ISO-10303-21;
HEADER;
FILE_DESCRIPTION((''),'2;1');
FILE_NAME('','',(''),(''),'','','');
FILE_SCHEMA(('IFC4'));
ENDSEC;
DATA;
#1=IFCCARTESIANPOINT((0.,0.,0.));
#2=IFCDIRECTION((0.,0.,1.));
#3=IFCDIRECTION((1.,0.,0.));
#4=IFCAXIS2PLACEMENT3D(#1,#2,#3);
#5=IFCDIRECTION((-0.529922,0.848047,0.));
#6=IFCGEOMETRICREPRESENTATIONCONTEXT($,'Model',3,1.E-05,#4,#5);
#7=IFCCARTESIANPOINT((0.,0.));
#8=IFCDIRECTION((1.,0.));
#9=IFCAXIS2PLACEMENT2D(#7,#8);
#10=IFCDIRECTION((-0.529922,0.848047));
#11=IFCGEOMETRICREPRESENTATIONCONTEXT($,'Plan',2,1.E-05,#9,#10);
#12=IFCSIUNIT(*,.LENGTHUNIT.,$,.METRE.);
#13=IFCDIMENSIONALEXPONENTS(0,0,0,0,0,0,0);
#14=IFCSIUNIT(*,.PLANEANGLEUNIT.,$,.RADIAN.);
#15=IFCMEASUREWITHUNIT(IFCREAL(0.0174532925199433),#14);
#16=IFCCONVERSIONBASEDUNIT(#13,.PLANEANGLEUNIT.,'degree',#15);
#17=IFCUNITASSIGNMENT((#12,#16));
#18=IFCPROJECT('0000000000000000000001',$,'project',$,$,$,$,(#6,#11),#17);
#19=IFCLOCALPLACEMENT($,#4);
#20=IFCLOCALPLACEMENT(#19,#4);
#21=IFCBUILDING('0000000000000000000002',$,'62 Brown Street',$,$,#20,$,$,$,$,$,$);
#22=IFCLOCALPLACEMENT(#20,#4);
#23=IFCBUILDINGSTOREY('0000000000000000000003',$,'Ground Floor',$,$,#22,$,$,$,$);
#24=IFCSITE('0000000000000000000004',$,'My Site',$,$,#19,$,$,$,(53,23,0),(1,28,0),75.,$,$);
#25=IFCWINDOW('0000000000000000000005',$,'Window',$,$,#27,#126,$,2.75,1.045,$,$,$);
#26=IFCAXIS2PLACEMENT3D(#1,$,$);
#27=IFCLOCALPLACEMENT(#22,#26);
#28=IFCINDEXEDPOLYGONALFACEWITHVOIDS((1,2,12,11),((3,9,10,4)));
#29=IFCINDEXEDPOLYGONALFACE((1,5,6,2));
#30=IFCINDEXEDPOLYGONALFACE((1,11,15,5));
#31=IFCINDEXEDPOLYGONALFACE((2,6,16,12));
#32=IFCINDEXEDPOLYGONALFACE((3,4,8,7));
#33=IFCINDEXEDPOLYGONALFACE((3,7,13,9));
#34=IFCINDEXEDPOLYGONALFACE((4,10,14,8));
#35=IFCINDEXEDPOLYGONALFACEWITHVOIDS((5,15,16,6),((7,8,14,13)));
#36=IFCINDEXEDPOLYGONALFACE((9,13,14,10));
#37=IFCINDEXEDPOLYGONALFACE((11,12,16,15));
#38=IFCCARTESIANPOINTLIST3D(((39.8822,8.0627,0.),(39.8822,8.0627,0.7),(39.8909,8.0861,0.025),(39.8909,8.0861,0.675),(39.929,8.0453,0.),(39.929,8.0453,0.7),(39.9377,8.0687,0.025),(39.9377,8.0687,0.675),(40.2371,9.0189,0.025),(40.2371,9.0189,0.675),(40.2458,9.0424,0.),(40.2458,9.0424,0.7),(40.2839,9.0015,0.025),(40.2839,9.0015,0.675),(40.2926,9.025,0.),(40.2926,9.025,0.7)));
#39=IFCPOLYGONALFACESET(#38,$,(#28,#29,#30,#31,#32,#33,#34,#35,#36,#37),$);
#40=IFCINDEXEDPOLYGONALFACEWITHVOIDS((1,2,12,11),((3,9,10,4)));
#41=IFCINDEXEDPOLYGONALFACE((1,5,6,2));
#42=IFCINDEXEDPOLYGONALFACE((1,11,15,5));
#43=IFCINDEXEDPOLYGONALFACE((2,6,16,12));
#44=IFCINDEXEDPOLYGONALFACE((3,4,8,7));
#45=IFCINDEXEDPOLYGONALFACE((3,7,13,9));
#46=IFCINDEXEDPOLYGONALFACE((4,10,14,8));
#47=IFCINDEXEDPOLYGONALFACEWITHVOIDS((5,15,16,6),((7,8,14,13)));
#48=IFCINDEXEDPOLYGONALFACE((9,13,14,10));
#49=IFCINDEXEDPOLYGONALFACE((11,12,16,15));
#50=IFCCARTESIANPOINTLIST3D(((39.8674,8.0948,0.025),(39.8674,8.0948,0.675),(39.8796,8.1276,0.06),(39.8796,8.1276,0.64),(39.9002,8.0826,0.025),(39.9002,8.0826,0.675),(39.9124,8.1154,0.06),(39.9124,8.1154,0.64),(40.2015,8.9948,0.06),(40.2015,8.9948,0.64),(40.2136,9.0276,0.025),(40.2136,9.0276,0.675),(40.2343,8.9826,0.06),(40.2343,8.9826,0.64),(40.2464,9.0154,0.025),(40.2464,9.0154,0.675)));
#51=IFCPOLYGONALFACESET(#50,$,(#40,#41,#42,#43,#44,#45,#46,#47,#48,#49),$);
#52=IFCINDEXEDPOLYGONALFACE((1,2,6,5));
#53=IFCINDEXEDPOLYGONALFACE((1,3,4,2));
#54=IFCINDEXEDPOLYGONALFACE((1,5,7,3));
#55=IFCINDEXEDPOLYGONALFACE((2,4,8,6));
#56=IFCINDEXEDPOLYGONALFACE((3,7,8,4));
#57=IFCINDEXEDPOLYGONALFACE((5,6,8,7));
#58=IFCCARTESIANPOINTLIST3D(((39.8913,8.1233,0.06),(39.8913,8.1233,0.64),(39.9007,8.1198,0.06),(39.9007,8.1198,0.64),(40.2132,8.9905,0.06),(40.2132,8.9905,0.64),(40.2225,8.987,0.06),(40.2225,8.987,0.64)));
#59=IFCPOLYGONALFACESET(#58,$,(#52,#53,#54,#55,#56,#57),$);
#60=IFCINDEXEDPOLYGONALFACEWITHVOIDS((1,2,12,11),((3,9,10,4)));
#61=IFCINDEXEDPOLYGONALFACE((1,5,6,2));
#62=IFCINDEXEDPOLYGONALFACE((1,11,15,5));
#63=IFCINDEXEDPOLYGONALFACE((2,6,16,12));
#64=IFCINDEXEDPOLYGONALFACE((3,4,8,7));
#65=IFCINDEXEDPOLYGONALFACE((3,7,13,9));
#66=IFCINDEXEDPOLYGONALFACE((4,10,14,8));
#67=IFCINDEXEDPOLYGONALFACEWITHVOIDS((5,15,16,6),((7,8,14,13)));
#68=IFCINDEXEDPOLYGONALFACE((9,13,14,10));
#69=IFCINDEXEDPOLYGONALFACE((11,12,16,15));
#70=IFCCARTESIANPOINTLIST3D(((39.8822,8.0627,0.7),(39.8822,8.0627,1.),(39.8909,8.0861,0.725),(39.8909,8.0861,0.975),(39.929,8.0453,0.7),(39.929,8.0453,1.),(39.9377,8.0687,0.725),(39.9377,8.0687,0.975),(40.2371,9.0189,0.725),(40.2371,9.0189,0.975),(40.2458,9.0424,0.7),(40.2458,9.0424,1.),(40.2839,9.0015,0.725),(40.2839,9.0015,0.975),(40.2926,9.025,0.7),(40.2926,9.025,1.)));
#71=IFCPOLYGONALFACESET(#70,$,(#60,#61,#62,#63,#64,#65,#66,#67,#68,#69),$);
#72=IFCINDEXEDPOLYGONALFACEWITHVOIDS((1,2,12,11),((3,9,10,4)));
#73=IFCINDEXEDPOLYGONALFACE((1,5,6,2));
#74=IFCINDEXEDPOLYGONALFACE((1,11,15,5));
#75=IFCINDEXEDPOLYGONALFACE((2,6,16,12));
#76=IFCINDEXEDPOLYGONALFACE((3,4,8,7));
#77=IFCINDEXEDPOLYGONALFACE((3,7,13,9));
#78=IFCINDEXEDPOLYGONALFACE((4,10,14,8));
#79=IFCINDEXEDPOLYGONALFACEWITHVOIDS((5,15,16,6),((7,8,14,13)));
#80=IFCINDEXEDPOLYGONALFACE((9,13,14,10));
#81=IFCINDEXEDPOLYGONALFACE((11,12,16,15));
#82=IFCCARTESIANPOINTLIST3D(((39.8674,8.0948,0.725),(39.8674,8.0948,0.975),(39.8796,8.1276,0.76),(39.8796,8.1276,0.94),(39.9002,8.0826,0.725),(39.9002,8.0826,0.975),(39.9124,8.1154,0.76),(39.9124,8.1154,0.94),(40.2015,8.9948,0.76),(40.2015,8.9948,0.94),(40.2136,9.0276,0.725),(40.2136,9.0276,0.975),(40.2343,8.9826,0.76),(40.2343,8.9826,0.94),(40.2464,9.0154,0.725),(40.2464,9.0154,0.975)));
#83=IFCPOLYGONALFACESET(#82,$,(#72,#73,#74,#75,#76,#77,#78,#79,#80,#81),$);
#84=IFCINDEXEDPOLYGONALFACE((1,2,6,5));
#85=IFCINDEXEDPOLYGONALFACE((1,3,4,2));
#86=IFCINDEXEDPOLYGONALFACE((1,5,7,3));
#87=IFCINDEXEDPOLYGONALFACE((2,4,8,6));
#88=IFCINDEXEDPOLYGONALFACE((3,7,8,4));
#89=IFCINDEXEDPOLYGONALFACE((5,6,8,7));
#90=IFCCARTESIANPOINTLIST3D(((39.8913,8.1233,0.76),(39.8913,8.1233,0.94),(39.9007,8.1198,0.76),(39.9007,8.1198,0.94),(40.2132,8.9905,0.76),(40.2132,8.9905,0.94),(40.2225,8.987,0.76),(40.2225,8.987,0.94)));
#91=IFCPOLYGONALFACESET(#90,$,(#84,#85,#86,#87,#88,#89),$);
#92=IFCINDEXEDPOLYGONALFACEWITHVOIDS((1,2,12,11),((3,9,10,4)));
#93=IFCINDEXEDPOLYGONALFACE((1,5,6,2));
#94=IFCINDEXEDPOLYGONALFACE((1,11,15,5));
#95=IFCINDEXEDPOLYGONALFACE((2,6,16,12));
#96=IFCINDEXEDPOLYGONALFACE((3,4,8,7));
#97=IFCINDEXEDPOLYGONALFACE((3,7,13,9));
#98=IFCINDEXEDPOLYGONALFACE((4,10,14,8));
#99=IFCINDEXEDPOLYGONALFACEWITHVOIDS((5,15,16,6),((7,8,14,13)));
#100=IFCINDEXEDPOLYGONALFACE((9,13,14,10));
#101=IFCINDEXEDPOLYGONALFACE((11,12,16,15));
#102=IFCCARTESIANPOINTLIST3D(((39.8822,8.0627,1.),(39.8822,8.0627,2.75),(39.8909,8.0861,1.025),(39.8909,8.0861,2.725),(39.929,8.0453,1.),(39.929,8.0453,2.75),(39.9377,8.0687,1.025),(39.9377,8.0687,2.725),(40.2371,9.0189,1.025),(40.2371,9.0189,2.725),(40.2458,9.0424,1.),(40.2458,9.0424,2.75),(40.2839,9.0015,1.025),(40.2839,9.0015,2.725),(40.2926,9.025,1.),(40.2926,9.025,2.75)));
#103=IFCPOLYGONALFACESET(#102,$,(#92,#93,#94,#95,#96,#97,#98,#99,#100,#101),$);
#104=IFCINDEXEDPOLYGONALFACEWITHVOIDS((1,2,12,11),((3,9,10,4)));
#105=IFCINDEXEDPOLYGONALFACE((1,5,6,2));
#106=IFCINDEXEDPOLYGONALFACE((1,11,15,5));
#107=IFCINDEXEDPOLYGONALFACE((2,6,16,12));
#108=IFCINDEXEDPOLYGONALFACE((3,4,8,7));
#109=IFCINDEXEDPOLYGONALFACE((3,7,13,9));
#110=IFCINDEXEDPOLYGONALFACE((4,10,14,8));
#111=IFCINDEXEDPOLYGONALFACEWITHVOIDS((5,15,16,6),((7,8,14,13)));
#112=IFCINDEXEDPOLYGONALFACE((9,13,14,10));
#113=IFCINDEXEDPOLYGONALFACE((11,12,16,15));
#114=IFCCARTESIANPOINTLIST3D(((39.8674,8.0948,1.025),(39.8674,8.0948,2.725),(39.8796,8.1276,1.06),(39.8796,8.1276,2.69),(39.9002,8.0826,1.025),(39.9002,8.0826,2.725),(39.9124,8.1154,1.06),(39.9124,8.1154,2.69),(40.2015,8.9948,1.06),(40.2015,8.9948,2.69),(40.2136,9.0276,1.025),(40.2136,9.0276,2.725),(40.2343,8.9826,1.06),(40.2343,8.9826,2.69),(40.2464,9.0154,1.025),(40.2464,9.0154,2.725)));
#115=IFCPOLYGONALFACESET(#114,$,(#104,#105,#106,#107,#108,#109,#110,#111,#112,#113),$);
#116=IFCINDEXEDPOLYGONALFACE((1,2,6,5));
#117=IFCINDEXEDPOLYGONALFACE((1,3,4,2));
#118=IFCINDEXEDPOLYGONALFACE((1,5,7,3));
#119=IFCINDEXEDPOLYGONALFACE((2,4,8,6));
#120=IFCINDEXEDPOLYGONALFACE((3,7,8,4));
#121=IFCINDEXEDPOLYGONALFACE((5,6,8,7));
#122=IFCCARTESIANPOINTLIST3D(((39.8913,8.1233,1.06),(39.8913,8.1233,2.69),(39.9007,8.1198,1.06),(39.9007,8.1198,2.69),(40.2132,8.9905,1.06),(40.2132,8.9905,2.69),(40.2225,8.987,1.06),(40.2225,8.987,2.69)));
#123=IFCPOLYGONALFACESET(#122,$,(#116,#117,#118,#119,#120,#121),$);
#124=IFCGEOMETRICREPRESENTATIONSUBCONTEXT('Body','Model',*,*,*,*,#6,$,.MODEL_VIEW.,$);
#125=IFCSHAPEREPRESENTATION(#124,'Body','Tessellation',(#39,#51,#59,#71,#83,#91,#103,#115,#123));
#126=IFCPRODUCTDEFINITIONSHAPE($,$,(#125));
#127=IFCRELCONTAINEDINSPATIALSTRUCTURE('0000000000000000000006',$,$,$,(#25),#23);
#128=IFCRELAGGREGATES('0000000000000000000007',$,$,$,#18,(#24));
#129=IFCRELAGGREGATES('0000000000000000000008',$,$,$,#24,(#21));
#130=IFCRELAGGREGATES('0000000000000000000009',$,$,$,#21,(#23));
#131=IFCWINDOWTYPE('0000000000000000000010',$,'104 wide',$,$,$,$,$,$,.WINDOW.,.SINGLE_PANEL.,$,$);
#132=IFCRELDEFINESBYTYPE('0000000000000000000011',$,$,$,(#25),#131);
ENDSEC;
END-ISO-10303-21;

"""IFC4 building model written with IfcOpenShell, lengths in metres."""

from ifc_helpers import new_model, entity, si_unit, converted_unit, direction, frame, origin_with_axes, origin_2d_with_axis, place, context, subcontext, project, spatial, line, indexed_curve, outline, extrude, shape, source, transform, mapped, type_object, type_shapes, element, save


model = new_model("IFC4")

# Units and contexts
model_context = context("Model", 3, precision=1e-05, world=origin_with_axes(), true_north=direction((-0.529922, 0.848047, 0.0)))
plan_context = context("Plan", 2, precision=1e-05, world=origin_2d_with_axis(), true_north=direction((-0.529922, 0.848047)))
body_context_1 = subcontext(model_context, "Body", "Model", "MODEL_VIEW")
body_context_2 = subcontext(plan_context, "Body", "Plan", "PLAN_VIEW")
ifc_project = project(units=[si_unit("LENGTHUNIT", "METRE"), converted_unit("PLANEANGLEUNIT", "degree", entity("IfcReal", 0.0174532925199433), si_unit("PLANEANGLEUNIT", "RADIAN"), dimensions=[0, 0, 0, 0, 0, 0, 0])], contexts=[model_context, plan_context])

# Site, building, storey
site_placement = place(None, origin_with_axes())
site = spatial("IfcSite", under=ifc_project, at=site_placement, Name="My Site", RefLatitude=(53, 23, 0), RefLongitude=(1, 28, 0), RefElevation=75.0)
building_placement = place(site_placement, origin_with_axes())
building = spatial("IfcBuilding", under=site, at=building_placement, Name="62 Brown Street")
storey_placement = place(building_placement, origin_with_axes())
storey = spatial("IfcBuildingStorey", under=building, at=storey_placement, Name="Ground Floor")

# Window
window_type_1 = type_object("IfcWindowType", Name="104 wide", PartitioningType="SINGLE_PANEL", PredefinedType="WINDOW")
shared_shape_1 = source(origin_with_axes(), body_context_1, "Body", "SweptSolid", [
    extrude(outline(indexed_curve([(0.0, 0.0), (1.045, 0.0), (1.045, 0.7), (0.0, 0.7)], segments=[line(1, 2, 3, 4, 1)]), holes=[indexed_curve([(0.025, 0.025), (1.02, 0.025), (1.02, 0.675), (0.025, 0.675)], segments=[line(1, 2, 3, 4, 1)])]), frame((0.0, 0.15, 0.0), z_axis=(0.0, -1.0, 0.0), x_axis=(1.0, 0.0, 0.0)), (0.0, 0.0, -1.0), 0.05),
    extrude(outline(indexed_curve([(0.0, 0.0), (0.995, 0.0), (0.995, 0.65), (0.0, 0.65)], segments=[line(1, 2, 3, 4, 1)]), holes=[indexed_curve([(0.035, 0.035), (0.96, 0.035), (0.96, 0.615), (0.035, 0.615)], segments=[line(1, 2, 3, 4, 1)])]), frame((0.025, 0.19, 0.025), z_axis=(0.0, -1.0, 0.0), x_axis=(1.0, 0.0, 0.0)), (0.0, 0.0, -1.0), 0.035),
    extrude(outline(indexed_curve([(0.035, 0.035), (0.96, 0.035), (0.96, 0.615), (0.035, 0.615)], segments=[line(1, 2, 3, 4, 1)])), frame((0.025, 0.2025, 0.025), z_axis=(0.0, -1.0, 0.0), x_axis=(1.0, 0.0, 0.0)), (0.0, 0.0, -1.0), 0.01),
    extrude(outline(indexed_curve([(0.0, 0.0), (1.045, 0.0), (1.045, 0.3), (0.0, 0.3)], segments=[line(1, 2, 3, 4, 1)]), holes=[indexed_curve([(0.025, 0.025), (1.02, 0.025), (1.02, 0.275), (0.025, 0.275)], segments=[line(1, 2, 3, 4, 1)])]), frame((0.0, 0.15, 0.7), z_axis=(0.0, -1.0, 0.0), x_axis=(1.0, 0.0, 0.0)), (0.0, 0.0, -1.0), 0.05),
    extrude(outline(indexed_curve([(0.0, 0.0), (0.995, 0.0), (0.995, 0.25), (0.0, 0.25)], segments=[line(1, 2, 3, 4, 1)]), holes=[indexed_curve([(0.035, 0.035), (0.96, 0.035), (0.96, 0.215), (0.035, 0.215)], segments=[line(1, 2, 3, 4, 1)])]), frame((0.025, 0.19, 0.725), z_axis=(0.0, -1.0, 0.0), x_axis=(1.0, 0.0, 0.0)), (0.0, 0.0, -1.0), 0.035),
    extrude(outline(indexed_curve([(0.035, 0.035), (0.96, 0.035), (0.96, 0.215), (0.035, 0.215)], segments=[line(1, 2, 3, 4, 1)])), frame((0.025, 0.2025, 0.725), z_axis=(0.0, -1.0, 0.0), x_axis=(1.0, 0.0, 0.0)), (0.0, 0.0, -1.0), 0.01),
    extrude(outline(indexed_curve([(0.0, 0.0), (1.045, 0.0), (1.045, 1.75), (0.0, 1.75)], segments=[line(1, 2, 3, 4, 1)]), holes=[indexed_curve([(0.025, 0.025), (1.02, 0.025), (1.02, 1.725), (0.025, 1.725)], segments=[line(1, 2, 3, 4, 1)])]), frame((0.0, 0.15, 1.0), z_axis=(0.0, -1.0, 0.0), x_axis=(1.0, 0.0, 0.0)), (0.0, 0.0, -1.0), 0.05),
    extrude(outline(indexed_curve([(0.0, 0.0), (0.995, 0.0), (0.995, 1.7), (0.0, 1.7)], segments=[line(1, 2, 3, 4, 1)]), holes=[indexed_curve([(0.035, 0.035), (0.96, 0.035), (0.96, 1.665), (0.035, 1.665)], segments=[line(1, 2, 3, 4, 1)])]), frame((0.025, 0.19, 1.025), z_axis=(0.0, -1.0, 0.0), x_axis=(1.0, 0.0, 0.0)), (0.0, 0.0, -1.0), 0.035),
    extrude(outline(indexed_curve([(0.035, 0.035), (0.96, 0.035), (0.96, 1.665), (0.035, 1.665)], segments=[line(1, 2, 3, 4, 1)])), frame((0.025, 0.2025, 1.025), z_axis=(0.0, -1.0, 0.0), x_axis=(1.0, 0.0, 0.0)), (0.0, 0.0, -1.0), 0.01),
])
shared_shape_2 = source(origin_with_axes(), body_context_2, "Body", "Curve2D", [
    entity("IfcIndexedPolyCurve", entity("IfcCartesianPointList2D", [[0.025, 0.15], [1.02, 0.15]])),
    entity("IfcIndexedPolyCurve", entity("IfcCartesianPointList2D", [[0.0, 0.2], [0.025, 0.2], [0.025, 0.15], [0.0, 0.15]]), [entity("IfcLineIndex", [1, 2, 3, 4, 1])]),
    entity("IfcIndexedPolyCurve", entity("IfcCartesianPointList2D", [[1.045, 0.2], [1.02, 0.2], [1.02, 0.15], [1.045, 0.15]]), [entity("IfcLineIndex", [1, 2, 3, 4, 1])]),
    entity("IfcIndexedPolyCurve", entity("IfcCartesianPointList2D", [[0.025, 0.19], [0.06, 0.19], [0.06, 0.225], [0.025, 0.225]]), [entity("IfcLineIndex", [1, 2, 3, 4, 1])]),
    entity("IfcIndexedPolyCurve", entity("IfcCartesianPointList2D", [[1.02, 0.19], [0.985, 0.19], [0.985, 0.225], [1.02, 0.225]]), [entity("IfcLineIndex", [1, 2, 3, 4, 1])]),
    entity("IfcIndexedPolyCurve", entity("IfcCartesianPointList2D", [[0.06, 0.19], [0.985, 0.19]])),
    entity("IfcIndexedPolyCurve", entity("IfcCartesianPointList2D", [[0.06, 0.225], [0.985, 0.225]])),
    entity("IfcIndexedPolyCurve", entity("IfcCartesianPointList2D", [[0.06, 0.2075], [0.985, 0.2075]])),
])
type_shapes(window_type_1, [shared_shape_1, shared_shape_2])
placement_1 = place(storey_placement, frame((39.024, 5.1755, 0.0), z_axis=(0.0, 0.0, 1.0), x_axis=(0.347944, 0.937515, 0.0)))
placement_2 = place(placement_1, frame((3.0054, 0.0, 0.0), z_axis=(0.0, 0.0, 1.0), x_axis=(1.0, 0.0, 0.0)))
window_1_placement = place(placement_2, frame((0.0, 0.0, 0.0), z_axis=(0.0, 0.0, 1.0), x_axis=(1.0, 0.0, 0.0)))
element("IfcWindow", 1, at=window_1_placement, inside=storey, type_object=window_type_1, Name="Window", OverallHeight=2.75, OverallWidth=1.045, shapes=[
    shape(body_context_1, "Body", "MappedRepresentation", [mapped(shared_shape_1, transform((0.0, 0.0, 0.0), x_axis=(1.0, 0.0, 0.0), y_axis=(0.0, 1.0, 0.0), z_axis=(0.0, 0.0, 1.0), scale=1.0))]),
    shape(body_context_2, "Body", "MappedRepresentation", [mapped(shared_shape_2, transform((0.0, 0.0, 0.0), x_axis=(1.0, 0.0, 0.0), y_axis=(0.0, 1.0, 0.0), z_axis=(0.0, 0.0, 1.0), scale=1.0))]),
])

save(model, "model.ifc")
